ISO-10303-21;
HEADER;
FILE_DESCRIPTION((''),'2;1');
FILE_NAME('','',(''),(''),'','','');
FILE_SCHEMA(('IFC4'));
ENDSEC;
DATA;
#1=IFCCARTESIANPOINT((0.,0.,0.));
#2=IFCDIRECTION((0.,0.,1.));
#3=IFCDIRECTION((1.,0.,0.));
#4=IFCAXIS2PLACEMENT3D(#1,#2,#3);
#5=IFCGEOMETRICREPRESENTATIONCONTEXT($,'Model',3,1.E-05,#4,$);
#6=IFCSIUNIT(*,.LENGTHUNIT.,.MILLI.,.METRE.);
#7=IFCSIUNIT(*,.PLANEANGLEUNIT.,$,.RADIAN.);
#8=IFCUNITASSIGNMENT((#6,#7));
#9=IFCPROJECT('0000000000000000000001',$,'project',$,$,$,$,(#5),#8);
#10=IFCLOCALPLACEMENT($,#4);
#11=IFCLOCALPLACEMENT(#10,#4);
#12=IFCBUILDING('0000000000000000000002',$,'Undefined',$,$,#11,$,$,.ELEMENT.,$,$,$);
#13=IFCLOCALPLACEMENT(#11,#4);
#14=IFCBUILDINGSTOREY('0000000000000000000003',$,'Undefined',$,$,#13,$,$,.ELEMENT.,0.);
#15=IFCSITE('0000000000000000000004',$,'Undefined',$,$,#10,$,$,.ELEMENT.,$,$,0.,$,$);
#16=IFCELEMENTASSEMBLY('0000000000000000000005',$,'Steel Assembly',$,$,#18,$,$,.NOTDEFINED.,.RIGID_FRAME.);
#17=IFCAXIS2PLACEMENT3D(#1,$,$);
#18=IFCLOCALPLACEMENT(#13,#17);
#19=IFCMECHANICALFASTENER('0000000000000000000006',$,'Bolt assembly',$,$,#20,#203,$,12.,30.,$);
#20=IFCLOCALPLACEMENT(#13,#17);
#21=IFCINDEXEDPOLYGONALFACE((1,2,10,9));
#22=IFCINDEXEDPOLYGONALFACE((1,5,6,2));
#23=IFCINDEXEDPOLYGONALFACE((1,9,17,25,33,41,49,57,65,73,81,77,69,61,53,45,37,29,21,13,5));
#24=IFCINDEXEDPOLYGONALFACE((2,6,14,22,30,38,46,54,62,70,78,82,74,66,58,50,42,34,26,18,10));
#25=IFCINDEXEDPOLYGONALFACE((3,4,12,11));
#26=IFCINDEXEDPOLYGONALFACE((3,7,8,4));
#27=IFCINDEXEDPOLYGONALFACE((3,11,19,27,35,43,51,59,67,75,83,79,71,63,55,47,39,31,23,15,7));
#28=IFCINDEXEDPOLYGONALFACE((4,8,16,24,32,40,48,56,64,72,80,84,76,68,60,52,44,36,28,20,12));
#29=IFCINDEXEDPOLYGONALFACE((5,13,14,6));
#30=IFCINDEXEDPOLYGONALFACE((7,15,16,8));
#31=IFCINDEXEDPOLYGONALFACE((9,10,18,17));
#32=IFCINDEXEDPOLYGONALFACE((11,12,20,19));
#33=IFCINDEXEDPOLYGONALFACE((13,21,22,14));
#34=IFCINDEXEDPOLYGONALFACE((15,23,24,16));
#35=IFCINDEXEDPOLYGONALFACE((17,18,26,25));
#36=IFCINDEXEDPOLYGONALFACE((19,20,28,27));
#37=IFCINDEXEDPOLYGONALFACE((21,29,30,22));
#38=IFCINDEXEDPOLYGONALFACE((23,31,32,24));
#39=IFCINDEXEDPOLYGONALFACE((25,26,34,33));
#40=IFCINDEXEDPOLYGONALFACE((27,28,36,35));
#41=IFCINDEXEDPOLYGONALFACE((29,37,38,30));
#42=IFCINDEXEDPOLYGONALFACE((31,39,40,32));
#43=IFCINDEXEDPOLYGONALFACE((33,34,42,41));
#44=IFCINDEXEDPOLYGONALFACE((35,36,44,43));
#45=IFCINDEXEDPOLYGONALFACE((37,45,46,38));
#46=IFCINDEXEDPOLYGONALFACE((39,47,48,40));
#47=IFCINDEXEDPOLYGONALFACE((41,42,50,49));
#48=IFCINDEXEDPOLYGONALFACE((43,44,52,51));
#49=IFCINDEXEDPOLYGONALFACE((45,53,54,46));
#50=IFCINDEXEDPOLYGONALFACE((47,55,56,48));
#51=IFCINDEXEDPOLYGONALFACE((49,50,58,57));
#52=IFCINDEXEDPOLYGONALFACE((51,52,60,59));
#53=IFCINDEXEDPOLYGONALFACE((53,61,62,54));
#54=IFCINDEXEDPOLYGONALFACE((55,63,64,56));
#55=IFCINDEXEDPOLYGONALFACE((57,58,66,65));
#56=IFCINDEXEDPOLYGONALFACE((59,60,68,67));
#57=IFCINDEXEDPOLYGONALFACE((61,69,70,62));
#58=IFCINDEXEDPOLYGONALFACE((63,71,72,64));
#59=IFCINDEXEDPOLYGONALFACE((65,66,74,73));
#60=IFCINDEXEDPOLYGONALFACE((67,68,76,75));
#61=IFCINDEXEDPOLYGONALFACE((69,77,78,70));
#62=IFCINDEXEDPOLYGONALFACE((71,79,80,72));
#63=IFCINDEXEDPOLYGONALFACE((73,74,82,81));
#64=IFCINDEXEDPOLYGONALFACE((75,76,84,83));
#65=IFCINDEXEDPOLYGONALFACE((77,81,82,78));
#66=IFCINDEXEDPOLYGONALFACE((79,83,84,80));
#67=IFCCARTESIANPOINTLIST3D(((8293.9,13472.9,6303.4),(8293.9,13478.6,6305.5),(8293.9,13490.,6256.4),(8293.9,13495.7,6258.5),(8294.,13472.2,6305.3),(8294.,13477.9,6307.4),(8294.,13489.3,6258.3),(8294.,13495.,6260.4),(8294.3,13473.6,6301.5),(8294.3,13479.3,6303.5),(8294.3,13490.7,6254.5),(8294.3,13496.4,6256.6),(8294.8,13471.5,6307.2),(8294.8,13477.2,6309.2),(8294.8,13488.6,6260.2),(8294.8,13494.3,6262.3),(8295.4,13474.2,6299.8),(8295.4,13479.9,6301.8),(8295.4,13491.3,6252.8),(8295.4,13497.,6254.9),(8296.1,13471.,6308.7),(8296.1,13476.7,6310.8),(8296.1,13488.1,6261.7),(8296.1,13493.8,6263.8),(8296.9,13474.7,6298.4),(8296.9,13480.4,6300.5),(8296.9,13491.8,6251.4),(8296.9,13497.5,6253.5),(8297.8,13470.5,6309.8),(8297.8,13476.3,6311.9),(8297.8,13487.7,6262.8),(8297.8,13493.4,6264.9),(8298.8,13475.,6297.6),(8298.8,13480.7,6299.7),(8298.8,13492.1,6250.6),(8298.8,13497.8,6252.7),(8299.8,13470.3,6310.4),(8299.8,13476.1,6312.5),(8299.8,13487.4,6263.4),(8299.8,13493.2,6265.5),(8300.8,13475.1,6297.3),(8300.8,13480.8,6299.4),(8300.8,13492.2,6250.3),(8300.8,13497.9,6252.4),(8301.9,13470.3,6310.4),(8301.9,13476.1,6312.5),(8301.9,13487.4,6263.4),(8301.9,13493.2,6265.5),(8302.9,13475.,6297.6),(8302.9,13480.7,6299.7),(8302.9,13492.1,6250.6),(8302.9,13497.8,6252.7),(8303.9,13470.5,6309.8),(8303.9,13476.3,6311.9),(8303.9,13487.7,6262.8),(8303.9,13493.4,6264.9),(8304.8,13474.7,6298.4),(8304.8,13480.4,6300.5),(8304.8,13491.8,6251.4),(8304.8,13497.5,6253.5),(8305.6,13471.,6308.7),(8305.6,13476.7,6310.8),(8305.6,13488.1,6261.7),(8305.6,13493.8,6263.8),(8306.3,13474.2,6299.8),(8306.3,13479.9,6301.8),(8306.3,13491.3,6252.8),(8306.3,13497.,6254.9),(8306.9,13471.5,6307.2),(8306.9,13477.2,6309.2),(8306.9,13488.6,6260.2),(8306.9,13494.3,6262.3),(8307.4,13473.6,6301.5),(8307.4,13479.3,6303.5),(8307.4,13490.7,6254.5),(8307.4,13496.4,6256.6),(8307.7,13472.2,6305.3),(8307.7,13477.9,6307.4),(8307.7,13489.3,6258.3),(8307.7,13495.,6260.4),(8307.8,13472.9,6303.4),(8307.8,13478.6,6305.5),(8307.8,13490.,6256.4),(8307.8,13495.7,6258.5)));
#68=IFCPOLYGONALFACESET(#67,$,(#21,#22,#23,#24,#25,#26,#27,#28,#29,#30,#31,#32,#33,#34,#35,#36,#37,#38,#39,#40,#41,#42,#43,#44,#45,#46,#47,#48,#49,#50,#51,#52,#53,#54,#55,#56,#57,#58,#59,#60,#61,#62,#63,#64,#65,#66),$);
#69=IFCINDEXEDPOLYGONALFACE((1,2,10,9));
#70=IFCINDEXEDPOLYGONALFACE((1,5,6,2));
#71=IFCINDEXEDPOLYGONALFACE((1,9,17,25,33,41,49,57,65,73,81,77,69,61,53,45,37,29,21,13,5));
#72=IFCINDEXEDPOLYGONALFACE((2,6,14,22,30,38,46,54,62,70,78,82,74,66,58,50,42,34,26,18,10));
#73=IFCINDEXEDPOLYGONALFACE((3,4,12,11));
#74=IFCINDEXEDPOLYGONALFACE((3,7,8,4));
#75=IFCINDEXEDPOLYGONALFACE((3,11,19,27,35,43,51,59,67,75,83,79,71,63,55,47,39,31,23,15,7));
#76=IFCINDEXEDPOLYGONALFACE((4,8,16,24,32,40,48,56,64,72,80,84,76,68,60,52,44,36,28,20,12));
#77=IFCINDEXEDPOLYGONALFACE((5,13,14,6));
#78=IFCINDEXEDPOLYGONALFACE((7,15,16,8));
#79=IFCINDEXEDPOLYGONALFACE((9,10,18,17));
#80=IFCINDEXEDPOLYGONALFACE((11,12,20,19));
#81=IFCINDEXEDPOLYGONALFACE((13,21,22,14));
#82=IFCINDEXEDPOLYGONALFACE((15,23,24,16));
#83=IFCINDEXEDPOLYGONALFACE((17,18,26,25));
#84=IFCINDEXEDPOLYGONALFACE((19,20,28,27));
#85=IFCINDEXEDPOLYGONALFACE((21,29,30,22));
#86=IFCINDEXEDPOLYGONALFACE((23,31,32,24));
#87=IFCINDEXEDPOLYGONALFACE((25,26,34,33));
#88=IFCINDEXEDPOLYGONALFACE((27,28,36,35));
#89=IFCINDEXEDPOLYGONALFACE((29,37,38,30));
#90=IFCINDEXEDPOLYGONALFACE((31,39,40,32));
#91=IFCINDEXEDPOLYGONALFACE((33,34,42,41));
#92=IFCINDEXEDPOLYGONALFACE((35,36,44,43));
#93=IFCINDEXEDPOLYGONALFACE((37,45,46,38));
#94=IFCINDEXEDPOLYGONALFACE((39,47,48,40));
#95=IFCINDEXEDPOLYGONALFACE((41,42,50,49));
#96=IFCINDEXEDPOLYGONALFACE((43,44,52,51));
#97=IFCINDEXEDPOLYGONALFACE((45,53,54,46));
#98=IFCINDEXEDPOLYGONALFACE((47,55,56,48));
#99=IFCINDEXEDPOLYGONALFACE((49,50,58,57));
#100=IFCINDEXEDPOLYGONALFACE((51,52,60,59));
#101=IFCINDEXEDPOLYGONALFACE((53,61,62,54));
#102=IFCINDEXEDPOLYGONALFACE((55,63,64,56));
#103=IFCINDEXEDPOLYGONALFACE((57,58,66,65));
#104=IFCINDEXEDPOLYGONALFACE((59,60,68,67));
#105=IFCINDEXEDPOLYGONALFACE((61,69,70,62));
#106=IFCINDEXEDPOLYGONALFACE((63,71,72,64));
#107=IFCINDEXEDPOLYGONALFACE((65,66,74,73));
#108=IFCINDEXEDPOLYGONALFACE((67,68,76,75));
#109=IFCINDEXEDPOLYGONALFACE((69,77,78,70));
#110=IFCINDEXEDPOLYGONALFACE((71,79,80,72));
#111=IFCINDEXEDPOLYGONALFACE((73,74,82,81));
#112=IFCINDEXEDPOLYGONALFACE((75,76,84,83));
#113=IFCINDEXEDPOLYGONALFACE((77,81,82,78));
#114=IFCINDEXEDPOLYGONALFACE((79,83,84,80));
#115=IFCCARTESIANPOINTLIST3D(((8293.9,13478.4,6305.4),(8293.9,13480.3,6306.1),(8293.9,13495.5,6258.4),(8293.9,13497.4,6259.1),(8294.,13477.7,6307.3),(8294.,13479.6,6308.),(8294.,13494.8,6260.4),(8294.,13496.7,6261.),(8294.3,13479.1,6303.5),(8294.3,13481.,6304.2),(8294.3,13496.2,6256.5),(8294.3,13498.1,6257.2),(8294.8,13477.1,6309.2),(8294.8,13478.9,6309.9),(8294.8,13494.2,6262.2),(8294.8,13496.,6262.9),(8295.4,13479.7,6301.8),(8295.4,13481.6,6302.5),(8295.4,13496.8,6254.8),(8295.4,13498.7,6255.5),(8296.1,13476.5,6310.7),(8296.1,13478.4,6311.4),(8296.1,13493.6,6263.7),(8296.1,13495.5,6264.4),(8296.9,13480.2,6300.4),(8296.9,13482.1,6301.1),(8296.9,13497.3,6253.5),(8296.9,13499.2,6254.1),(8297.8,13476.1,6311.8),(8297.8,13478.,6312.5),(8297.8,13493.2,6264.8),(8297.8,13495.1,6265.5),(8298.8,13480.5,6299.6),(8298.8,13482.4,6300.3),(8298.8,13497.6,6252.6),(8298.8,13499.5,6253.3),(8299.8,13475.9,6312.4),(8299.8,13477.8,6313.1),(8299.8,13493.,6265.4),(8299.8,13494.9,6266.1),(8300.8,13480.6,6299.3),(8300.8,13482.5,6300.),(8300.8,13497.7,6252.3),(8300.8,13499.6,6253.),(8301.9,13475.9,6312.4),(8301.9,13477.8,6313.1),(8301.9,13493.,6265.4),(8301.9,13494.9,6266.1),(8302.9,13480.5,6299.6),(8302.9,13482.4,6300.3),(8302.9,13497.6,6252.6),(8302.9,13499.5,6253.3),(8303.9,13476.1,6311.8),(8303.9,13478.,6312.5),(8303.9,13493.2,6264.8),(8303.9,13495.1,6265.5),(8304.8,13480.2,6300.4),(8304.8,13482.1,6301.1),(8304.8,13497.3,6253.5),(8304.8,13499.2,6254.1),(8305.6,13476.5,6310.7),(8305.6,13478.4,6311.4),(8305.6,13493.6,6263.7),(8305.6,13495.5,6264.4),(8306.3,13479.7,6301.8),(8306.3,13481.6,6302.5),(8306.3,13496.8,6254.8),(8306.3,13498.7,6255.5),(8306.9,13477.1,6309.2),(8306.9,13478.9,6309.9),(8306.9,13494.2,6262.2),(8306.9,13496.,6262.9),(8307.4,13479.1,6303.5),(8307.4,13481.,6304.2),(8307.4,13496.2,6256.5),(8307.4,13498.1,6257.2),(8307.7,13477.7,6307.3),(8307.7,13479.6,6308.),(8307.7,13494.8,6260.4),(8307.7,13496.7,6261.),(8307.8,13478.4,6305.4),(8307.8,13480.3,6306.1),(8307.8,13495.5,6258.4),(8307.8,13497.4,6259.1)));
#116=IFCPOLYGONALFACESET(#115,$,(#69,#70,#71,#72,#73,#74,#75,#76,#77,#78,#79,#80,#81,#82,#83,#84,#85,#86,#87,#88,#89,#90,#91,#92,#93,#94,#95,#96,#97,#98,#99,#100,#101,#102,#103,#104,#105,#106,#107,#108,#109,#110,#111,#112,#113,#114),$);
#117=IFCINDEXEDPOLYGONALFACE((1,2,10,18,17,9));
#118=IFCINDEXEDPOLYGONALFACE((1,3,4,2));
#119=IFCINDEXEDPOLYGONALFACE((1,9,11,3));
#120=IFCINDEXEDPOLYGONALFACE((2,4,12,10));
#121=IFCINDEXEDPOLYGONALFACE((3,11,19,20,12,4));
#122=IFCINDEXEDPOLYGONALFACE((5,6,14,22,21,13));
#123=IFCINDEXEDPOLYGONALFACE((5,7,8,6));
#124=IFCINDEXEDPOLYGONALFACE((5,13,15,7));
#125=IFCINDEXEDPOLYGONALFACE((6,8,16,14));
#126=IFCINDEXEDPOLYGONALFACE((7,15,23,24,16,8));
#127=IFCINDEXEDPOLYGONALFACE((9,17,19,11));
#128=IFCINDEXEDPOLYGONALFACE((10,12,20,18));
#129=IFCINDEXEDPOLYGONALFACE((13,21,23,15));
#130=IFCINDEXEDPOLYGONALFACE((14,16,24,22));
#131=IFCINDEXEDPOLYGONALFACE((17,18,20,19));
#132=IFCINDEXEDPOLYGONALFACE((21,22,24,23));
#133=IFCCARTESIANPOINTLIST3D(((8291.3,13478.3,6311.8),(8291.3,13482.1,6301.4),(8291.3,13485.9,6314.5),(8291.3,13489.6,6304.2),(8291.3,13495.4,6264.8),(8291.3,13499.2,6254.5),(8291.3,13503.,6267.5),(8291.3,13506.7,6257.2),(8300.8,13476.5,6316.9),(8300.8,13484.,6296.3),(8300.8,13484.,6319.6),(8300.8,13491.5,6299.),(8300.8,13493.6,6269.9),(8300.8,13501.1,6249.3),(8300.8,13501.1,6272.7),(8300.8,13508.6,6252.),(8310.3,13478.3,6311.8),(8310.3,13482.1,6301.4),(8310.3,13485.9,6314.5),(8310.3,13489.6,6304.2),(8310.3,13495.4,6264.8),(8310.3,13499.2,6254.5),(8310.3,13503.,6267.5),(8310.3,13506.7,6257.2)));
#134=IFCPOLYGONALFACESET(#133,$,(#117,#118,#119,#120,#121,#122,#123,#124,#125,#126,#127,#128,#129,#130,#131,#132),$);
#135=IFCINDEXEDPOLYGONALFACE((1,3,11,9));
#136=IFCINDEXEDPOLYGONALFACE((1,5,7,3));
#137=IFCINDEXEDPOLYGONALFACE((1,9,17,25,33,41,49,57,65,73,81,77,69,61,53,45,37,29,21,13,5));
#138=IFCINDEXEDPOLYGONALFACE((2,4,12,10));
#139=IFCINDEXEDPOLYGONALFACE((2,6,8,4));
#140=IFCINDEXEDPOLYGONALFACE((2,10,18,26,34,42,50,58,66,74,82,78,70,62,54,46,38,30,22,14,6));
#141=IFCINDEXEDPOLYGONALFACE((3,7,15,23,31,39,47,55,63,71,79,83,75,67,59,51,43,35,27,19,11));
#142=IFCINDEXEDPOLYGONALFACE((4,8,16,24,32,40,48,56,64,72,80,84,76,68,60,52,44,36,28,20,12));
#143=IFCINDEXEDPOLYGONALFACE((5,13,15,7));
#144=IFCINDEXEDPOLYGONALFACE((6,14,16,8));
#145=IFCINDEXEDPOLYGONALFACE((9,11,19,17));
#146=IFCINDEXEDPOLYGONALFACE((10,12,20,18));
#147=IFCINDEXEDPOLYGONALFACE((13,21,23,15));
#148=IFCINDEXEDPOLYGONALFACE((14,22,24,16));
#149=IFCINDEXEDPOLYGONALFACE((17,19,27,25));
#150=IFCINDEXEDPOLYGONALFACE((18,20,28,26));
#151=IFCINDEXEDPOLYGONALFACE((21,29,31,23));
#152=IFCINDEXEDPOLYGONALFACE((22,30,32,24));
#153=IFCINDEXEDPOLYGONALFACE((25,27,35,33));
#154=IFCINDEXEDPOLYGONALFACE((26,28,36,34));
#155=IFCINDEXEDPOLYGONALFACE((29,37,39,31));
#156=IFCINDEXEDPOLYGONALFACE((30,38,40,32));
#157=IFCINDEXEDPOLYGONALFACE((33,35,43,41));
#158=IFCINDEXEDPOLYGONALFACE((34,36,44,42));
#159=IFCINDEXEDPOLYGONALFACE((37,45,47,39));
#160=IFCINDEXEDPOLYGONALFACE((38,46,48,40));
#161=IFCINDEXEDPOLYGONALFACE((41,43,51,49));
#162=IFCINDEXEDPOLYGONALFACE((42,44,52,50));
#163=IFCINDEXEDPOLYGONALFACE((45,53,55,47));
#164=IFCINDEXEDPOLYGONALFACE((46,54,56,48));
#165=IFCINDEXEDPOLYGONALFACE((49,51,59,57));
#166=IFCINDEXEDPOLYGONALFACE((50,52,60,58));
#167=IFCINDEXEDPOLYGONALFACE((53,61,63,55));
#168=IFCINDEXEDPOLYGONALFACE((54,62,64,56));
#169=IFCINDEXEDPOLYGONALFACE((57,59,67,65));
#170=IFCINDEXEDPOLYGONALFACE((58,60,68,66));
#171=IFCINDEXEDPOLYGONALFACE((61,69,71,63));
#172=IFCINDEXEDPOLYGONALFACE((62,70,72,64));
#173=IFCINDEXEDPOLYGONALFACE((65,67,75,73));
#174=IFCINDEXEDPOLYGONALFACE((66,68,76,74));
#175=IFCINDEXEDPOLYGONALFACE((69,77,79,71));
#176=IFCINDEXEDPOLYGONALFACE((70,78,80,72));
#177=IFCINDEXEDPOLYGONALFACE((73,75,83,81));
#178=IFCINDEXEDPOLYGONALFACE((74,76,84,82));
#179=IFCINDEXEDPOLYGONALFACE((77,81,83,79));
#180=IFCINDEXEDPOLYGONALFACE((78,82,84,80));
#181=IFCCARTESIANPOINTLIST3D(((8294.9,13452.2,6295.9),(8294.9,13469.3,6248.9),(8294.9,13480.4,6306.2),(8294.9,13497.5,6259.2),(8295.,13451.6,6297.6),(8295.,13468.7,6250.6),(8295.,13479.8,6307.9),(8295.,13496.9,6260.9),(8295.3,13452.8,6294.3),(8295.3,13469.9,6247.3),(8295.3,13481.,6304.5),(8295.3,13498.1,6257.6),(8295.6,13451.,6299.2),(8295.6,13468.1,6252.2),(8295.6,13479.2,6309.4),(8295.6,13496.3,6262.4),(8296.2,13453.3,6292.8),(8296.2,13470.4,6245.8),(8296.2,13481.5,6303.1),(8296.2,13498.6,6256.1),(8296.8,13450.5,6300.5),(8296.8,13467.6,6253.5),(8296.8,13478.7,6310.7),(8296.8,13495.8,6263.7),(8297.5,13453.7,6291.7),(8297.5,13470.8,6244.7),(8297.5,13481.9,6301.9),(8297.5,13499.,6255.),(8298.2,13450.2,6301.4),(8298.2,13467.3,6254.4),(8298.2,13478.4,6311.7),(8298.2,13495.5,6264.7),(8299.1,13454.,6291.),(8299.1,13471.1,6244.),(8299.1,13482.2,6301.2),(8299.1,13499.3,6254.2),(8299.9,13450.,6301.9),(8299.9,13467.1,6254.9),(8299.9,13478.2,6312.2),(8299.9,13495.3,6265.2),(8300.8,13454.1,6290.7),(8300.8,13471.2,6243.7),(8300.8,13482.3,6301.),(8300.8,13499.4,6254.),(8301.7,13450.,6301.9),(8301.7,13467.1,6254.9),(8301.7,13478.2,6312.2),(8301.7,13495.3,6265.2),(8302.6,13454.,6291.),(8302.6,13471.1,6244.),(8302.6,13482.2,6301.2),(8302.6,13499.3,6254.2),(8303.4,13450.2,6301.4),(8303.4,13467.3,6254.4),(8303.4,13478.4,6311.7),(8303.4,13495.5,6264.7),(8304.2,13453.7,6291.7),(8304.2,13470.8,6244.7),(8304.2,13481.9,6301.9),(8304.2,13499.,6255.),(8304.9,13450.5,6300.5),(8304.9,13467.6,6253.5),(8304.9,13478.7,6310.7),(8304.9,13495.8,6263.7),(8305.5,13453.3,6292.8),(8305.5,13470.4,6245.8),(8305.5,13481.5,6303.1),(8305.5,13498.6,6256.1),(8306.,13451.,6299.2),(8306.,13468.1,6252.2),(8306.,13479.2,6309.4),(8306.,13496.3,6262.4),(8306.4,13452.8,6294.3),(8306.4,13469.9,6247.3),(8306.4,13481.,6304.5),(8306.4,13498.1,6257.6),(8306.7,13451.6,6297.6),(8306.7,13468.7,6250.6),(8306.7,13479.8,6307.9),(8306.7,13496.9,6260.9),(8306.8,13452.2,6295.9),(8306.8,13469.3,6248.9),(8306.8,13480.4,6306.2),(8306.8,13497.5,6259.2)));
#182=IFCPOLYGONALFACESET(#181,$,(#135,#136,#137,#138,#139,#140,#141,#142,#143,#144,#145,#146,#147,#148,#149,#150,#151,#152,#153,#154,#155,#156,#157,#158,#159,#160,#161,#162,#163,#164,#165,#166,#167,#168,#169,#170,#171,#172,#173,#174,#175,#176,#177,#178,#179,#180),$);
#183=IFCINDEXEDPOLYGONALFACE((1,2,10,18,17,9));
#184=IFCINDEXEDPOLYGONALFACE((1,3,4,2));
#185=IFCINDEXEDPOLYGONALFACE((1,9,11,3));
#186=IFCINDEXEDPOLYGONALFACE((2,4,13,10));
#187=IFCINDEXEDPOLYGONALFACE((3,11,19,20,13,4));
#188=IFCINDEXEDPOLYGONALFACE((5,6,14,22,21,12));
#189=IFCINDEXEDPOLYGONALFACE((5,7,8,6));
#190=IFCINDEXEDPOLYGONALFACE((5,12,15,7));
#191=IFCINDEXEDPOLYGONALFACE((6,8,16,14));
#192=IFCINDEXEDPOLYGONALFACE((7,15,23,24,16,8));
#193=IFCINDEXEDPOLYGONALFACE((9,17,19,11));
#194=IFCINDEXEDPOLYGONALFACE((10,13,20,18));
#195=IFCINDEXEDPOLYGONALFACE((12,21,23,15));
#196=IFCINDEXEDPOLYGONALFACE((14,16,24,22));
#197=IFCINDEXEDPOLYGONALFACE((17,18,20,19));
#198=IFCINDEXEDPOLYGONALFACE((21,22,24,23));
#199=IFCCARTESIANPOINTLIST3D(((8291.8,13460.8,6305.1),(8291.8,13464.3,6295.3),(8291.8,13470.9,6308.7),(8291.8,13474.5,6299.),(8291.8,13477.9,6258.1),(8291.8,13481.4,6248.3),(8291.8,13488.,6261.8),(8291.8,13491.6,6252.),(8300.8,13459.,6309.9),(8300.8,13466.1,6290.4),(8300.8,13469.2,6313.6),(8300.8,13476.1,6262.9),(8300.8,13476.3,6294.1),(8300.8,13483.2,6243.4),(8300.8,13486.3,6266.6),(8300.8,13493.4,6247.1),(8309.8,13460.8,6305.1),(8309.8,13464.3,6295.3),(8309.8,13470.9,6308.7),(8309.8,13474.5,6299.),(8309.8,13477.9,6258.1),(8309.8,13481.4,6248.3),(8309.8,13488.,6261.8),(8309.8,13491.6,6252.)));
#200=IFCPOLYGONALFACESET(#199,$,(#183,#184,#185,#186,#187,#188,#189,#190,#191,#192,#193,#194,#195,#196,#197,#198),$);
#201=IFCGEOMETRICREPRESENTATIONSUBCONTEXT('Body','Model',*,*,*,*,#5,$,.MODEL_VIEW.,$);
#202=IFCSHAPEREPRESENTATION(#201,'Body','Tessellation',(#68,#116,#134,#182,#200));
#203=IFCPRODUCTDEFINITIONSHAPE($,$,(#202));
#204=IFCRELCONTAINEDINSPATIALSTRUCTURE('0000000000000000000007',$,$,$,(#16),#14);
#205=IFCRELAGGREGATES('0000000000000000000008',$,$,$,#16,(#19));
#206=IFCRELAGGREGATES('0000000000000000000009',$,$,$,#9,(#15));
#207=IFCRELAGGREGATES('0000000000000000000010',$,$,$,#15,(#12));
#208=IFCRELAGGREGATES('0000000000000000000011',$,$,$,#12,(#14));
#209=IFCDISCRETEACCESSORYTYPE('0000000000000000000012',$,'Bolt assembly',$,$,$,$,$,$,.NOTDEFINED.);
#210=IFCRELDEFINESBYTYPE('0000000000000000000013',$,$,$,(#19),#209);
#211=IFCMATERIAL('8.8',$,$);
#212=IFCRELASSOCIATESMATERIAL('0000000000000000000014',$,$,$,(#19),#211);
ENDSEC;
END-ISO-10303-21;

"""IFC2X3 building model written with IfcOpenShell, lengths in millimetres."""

from ifc_helpers import new_model, si_unit, frame, origin_with_axes, origin_2d_with_axis, place, context, subcontext, project, spatial, polyline, circle, outline, extrude, source, transform, mapped, material, type_object, element, aggregate, save


model = new_model("IFC2X3")

# Units and contexts
model_context = context("Model", 3, precision=1e-05, world=origin_with_axes())
body_context = subcontext(model_context, "Body", "Model", "MODEL_VIEW")
ifc_project = project(units=[si_unit("LENGTHUNIT", "METRE", prefix="MILLI"), si_unit("PLANEANGLEUNIT", "RADIAN")], contexts=[model_context])

# Site, building, storey
site_placement = place(None, origin_with_axes())
site = spatial("IfcSite", under=ifc_project, at=site_placement, Name="Undefined", CompositionType="ELEMENT", RefElevation=0.0)
building_placement = place(site_placement, origin_with_axes())
building = spatial("IfcBuilding", under=site, at=building_placement, Name="Undefined", CompositionType="ELEMENT")
storey_placement = place(building_placement, origin_with_axes())
storey = spatial("IfcBuildingStorey", under=building, at=storey_placement, Name="Undefined", CompositionType="ELEMENT", Elevation=0.0)

# Shared definitions
ifc_material_1 = material(Name="8.8")
discrete_accessory_type_1 = type_object("IfcDiscreteAccessoryType", Name="Bolt assembly")

# Element assembly, mechanical fastener
shared_shape_1 = source(origin_with_axes(), body_context, "Body", "SweptSolid", [
    extrude(circle(Radius=7.0, at=origin_2d_with_axis()), frame((0.0, -6.1, 0.0), z_axis=(0.0, 1.0, 0.0), x_axis=(1.0, 0.0, 0.0)), (0.0, 0.0, 1.0), 6.1),
    extrude(circle(Radius=7.0, at=origin_2d_with_axis()), frame((0.0, -7.9, 0.0), z_axis=(0.0, 1.0, 0.0), x_axis=(1.0, 0.0, 0.0)), (0.0, 0.0, 1.0), 2.0),
    extrude(outline(polyline([(11.0, 0.0), (5.5, 9.5), (-5.5, 9.5), (-11.0, 0.0), (-5.5, -9.5), (5.5, -9.5), (11.0, 0.0)])), frame((0.0, -16.0, 0.0), z_axis=(0.0, 1.0, 0.0), x_axis=(1.0, 0.0, 0.0)), (0.0, 0.0, 1.0), 8.0),
    extrude(circle(Radius=6.0, at=origin_2d_with_axis()), frame((0.0, -8.0, 0.0), z_axis=(0.0, 1.0, 0.0), x_axis=(1.0, 0.0, 0.0)), (0.0, 0.0, 1.0), 30.0),
    extrude(outline(polyline([(10.4, 0.0), (5.2, 9.0), (-5.2, 9.0), (-10.4, 0.0), (-5.2, -9.0), (5.2, -9.0), (10.4, 0.0)])), frame((0.0, 0.0, 0.0), z_axis=(0.0, 1.0, 0.0), x_axis=(1.0, 0.0, 0.0)), (0.0, 0.0, 1.0), 10.8),
])
assembly_1_placement = place(storey_placement, origin_with_axes())
assembly_1 = element("IfcElementAssembly", 1, at=assembly_1_placement, inside=storey, Name="Steel Assembly", AssemblyPlace="NOTDEFINED", PredefinedType="RIGID_FRAME")
mechanical_fastener_1_placement = place(assembly_1_placement, frame((8300.8, 13472.7, 6303.9), z_axis=(-1.0, 0.0, 0.0), x_axis=(0.0, 0.34202, -0.939693)))
mechanical_fastener_1 = element("IfcMechanicalFastener", 2, at=mechanical_fastener_1_placement, type_object=discrete_accessory_type_1, material=ifc_material_1, Name="Bolt assembly", NominalDiameter=12.0, NominalLength=30.0, context=body_context, shape_type="MappedRepresentation", body=[
    mapped(shared_shape_1, transform((0.0, 0.0, 0.0))),
    mapped(shared_shape_1, transform((50.0, 0.0, 0.0))),
])
aggregate(assembly_1, [mechanical_fastener_1])

save(model, "model.ifc")
